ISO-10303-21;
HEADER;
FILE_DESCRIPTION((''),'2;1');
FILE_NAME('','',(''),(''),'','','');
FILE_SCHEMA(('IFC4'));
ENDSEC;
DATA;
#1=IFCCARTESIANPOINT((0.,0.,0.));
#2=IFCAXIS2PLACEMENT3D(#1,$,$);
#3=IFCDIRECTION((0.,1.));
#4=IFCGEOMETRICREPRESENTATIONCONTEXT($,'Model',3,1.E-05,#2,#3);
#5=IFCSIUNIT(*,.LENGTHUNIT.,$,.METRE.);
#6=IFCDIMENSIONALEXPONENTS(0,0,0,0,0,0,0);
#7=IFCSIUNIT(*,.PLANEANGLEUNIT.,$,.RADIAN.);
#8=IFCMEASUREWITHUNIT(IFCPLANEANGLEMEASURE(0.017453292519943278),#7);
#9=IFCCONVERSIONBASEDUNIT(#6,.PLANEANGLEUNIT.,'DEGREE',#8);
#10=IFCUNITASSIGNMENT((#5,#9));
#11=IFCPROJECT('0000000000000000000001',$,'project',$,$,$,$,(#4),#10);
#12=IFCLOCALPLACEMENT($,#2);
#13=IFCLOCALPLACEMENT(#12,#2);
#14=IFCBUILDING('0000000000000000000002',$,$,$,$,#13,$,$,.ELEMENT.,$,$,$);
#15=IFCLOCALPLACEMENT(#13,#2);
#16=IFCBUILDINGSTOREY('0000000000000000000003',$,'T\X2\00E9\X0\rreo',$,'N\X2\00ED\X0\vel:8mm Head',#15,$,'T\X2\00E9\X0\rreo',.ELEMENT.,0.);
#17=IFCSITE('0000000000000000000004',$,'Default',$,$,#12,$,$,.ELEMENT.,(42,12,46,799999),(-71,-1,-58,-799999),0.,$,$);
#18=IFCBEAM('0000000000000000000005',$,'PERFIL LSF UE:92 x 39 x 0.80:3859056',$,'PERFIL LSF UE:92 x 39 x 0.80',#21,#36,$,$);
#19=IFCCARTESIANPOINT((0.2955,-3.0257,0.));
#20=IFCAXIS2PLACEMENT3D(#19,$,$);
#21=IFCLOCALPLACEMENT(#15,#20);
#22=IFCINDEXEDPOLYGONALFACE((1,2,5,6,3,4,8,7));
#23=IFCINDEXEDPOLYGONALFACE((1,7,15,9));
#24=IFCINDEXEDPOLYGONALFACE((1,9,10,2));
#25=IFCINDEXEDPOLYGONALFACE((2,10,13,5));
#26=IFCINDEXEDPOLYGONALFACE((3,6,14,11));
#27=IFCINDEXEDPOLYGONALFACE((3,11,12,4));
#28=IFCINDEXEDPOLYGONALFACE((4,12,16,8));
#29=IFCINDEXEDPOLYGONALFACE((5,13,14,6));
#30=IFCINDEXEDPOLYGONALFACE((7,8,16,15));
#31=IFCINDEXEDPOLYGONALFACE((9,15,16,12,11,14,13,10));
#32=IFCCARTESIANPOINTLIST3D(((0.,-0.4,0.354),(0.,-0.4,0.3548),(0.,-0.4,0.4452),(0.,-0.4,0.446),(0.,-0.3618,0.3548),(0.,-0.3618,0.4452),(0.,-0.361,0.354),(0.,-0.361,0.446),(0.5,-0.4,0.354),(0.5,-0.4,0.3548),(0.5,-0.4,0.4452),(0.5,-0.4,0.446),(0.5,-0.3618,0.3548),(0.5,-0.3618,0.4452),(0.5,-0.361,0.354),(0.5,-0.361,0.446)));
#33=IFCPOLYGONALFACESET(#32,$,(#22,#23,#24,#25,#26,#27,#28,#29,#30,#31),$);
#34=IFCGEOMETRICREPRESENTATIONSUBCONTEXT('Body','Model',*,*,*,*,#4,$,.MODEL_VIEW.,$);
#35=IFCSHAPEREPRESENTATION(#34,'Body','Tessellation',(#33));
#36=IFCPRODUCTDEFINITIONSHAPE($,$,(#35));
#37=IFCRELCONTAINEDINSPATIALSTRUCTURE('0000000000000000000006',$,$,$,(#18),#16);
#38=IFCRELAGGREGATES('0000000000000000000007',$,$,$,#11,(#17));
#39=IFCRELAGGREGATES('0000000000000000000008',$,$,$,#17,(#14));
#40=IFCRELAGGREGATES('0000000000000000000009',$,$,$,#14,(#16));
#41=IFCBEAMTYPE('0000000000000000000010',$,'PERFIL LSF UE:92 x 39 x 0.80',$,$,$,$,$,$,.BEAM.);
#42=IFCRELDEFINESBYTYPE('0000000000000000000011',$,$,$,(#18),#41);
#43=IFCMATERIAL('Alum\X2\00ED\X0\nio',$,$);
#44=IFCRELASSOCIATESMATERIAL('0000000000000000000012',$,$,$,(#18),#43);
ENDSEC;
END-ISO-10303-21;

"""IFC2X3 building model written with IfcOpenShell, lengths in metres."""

from ifc_helpers import new_model, entity, si_unit, converted_unit, direction, frame, origin, place, context, subcontext, project, spatial, polyline, outline, extrude, material, type_object, element, save


model = new_model("IFC2X3")

# Units and contexts
model_context = context("Model", 3, precision=1e-05, world=origin(), true_north=direction((0.0, 1.0)))
body_context = subcontext(model_context, "Body", "Model", "MODEL_VIEW")
ifc_project = project(units=[si_unit("LENGTHUNIT", "METRE"), converted_unit("PLANEANGLEUNIT", "DEGREE", entity("IfcPlaneAngleMeasure", 0.017453292519943278), si_unit("PLANEANGLEUNIT", "RADIAN"), dimensions=[0, 0, 0, 0, 0, 0, 0])], contexts=[model_context])

# Site, building, storey
site_placement = place(None, origin())
site = spatial("IfcSite", under=ifc_project, at=site_placement, Name="Default", CompositionType="ELEMENT", RefLatitude=(42, 12, 46, 799999), RefLongitude=(-71, -1, -58, -799999), RefElevation=0.0)
building_placement = place(site_placement, origin())
building = spatial("IfcBuilding", under=site, at=building_placement, CompositionType="ELEMENT")
storey_placement = place(building_placement, origin())
storey = spatial("IfcBuildingStorey", under=building, at=storey_placement, Name="Térreo", ObjectType="Nível:8mm Head", LongName="Térreo", CompositionType="ELEMENT", Elevation=0.0)

# Beam
ifc_material_1 = material(Name="Alumínio")
beam_type_1 = type_object("IfcBeamType", Name="PERFIL LSF UE:92 x 39 x 0.80", PredefinedType="BEAM")
beam_1_placement = place(storey_placement, frame((0.2955, -3.0257, 0.0)))
element("IfcBeam", 1, at=beam_1_placement, inside=storey, type_object=beam_type_1, material=ifc_material_1, Name="PERFIL LSF UE:92 x 39 x 0.80:3859056", ObjectType="PERFIL LSF UE:92 x 39 x 0.80", context=body_context, shape_type="SweptSolid", body=[
    extrude(outline(polyline([(-0.046, -0.0193), (-0.0452, -0.0193), (-0.0452, 0.0189), (0.0452, 0.0189), (0.0452, -0.0193), (0.046, -0.0193), (0.046, 0.0197), (-0.046, 0.0197), (-0.046, -0.0193)])), frame((0.0, -0.3807, 0.4), z_axis=(1.0, 0.0, 0.0), x_axis=(0.0, 0.0, -1.0)), (0.0, 0.0, 1.0), 0.5),
])

save(model, "model.ifc")
